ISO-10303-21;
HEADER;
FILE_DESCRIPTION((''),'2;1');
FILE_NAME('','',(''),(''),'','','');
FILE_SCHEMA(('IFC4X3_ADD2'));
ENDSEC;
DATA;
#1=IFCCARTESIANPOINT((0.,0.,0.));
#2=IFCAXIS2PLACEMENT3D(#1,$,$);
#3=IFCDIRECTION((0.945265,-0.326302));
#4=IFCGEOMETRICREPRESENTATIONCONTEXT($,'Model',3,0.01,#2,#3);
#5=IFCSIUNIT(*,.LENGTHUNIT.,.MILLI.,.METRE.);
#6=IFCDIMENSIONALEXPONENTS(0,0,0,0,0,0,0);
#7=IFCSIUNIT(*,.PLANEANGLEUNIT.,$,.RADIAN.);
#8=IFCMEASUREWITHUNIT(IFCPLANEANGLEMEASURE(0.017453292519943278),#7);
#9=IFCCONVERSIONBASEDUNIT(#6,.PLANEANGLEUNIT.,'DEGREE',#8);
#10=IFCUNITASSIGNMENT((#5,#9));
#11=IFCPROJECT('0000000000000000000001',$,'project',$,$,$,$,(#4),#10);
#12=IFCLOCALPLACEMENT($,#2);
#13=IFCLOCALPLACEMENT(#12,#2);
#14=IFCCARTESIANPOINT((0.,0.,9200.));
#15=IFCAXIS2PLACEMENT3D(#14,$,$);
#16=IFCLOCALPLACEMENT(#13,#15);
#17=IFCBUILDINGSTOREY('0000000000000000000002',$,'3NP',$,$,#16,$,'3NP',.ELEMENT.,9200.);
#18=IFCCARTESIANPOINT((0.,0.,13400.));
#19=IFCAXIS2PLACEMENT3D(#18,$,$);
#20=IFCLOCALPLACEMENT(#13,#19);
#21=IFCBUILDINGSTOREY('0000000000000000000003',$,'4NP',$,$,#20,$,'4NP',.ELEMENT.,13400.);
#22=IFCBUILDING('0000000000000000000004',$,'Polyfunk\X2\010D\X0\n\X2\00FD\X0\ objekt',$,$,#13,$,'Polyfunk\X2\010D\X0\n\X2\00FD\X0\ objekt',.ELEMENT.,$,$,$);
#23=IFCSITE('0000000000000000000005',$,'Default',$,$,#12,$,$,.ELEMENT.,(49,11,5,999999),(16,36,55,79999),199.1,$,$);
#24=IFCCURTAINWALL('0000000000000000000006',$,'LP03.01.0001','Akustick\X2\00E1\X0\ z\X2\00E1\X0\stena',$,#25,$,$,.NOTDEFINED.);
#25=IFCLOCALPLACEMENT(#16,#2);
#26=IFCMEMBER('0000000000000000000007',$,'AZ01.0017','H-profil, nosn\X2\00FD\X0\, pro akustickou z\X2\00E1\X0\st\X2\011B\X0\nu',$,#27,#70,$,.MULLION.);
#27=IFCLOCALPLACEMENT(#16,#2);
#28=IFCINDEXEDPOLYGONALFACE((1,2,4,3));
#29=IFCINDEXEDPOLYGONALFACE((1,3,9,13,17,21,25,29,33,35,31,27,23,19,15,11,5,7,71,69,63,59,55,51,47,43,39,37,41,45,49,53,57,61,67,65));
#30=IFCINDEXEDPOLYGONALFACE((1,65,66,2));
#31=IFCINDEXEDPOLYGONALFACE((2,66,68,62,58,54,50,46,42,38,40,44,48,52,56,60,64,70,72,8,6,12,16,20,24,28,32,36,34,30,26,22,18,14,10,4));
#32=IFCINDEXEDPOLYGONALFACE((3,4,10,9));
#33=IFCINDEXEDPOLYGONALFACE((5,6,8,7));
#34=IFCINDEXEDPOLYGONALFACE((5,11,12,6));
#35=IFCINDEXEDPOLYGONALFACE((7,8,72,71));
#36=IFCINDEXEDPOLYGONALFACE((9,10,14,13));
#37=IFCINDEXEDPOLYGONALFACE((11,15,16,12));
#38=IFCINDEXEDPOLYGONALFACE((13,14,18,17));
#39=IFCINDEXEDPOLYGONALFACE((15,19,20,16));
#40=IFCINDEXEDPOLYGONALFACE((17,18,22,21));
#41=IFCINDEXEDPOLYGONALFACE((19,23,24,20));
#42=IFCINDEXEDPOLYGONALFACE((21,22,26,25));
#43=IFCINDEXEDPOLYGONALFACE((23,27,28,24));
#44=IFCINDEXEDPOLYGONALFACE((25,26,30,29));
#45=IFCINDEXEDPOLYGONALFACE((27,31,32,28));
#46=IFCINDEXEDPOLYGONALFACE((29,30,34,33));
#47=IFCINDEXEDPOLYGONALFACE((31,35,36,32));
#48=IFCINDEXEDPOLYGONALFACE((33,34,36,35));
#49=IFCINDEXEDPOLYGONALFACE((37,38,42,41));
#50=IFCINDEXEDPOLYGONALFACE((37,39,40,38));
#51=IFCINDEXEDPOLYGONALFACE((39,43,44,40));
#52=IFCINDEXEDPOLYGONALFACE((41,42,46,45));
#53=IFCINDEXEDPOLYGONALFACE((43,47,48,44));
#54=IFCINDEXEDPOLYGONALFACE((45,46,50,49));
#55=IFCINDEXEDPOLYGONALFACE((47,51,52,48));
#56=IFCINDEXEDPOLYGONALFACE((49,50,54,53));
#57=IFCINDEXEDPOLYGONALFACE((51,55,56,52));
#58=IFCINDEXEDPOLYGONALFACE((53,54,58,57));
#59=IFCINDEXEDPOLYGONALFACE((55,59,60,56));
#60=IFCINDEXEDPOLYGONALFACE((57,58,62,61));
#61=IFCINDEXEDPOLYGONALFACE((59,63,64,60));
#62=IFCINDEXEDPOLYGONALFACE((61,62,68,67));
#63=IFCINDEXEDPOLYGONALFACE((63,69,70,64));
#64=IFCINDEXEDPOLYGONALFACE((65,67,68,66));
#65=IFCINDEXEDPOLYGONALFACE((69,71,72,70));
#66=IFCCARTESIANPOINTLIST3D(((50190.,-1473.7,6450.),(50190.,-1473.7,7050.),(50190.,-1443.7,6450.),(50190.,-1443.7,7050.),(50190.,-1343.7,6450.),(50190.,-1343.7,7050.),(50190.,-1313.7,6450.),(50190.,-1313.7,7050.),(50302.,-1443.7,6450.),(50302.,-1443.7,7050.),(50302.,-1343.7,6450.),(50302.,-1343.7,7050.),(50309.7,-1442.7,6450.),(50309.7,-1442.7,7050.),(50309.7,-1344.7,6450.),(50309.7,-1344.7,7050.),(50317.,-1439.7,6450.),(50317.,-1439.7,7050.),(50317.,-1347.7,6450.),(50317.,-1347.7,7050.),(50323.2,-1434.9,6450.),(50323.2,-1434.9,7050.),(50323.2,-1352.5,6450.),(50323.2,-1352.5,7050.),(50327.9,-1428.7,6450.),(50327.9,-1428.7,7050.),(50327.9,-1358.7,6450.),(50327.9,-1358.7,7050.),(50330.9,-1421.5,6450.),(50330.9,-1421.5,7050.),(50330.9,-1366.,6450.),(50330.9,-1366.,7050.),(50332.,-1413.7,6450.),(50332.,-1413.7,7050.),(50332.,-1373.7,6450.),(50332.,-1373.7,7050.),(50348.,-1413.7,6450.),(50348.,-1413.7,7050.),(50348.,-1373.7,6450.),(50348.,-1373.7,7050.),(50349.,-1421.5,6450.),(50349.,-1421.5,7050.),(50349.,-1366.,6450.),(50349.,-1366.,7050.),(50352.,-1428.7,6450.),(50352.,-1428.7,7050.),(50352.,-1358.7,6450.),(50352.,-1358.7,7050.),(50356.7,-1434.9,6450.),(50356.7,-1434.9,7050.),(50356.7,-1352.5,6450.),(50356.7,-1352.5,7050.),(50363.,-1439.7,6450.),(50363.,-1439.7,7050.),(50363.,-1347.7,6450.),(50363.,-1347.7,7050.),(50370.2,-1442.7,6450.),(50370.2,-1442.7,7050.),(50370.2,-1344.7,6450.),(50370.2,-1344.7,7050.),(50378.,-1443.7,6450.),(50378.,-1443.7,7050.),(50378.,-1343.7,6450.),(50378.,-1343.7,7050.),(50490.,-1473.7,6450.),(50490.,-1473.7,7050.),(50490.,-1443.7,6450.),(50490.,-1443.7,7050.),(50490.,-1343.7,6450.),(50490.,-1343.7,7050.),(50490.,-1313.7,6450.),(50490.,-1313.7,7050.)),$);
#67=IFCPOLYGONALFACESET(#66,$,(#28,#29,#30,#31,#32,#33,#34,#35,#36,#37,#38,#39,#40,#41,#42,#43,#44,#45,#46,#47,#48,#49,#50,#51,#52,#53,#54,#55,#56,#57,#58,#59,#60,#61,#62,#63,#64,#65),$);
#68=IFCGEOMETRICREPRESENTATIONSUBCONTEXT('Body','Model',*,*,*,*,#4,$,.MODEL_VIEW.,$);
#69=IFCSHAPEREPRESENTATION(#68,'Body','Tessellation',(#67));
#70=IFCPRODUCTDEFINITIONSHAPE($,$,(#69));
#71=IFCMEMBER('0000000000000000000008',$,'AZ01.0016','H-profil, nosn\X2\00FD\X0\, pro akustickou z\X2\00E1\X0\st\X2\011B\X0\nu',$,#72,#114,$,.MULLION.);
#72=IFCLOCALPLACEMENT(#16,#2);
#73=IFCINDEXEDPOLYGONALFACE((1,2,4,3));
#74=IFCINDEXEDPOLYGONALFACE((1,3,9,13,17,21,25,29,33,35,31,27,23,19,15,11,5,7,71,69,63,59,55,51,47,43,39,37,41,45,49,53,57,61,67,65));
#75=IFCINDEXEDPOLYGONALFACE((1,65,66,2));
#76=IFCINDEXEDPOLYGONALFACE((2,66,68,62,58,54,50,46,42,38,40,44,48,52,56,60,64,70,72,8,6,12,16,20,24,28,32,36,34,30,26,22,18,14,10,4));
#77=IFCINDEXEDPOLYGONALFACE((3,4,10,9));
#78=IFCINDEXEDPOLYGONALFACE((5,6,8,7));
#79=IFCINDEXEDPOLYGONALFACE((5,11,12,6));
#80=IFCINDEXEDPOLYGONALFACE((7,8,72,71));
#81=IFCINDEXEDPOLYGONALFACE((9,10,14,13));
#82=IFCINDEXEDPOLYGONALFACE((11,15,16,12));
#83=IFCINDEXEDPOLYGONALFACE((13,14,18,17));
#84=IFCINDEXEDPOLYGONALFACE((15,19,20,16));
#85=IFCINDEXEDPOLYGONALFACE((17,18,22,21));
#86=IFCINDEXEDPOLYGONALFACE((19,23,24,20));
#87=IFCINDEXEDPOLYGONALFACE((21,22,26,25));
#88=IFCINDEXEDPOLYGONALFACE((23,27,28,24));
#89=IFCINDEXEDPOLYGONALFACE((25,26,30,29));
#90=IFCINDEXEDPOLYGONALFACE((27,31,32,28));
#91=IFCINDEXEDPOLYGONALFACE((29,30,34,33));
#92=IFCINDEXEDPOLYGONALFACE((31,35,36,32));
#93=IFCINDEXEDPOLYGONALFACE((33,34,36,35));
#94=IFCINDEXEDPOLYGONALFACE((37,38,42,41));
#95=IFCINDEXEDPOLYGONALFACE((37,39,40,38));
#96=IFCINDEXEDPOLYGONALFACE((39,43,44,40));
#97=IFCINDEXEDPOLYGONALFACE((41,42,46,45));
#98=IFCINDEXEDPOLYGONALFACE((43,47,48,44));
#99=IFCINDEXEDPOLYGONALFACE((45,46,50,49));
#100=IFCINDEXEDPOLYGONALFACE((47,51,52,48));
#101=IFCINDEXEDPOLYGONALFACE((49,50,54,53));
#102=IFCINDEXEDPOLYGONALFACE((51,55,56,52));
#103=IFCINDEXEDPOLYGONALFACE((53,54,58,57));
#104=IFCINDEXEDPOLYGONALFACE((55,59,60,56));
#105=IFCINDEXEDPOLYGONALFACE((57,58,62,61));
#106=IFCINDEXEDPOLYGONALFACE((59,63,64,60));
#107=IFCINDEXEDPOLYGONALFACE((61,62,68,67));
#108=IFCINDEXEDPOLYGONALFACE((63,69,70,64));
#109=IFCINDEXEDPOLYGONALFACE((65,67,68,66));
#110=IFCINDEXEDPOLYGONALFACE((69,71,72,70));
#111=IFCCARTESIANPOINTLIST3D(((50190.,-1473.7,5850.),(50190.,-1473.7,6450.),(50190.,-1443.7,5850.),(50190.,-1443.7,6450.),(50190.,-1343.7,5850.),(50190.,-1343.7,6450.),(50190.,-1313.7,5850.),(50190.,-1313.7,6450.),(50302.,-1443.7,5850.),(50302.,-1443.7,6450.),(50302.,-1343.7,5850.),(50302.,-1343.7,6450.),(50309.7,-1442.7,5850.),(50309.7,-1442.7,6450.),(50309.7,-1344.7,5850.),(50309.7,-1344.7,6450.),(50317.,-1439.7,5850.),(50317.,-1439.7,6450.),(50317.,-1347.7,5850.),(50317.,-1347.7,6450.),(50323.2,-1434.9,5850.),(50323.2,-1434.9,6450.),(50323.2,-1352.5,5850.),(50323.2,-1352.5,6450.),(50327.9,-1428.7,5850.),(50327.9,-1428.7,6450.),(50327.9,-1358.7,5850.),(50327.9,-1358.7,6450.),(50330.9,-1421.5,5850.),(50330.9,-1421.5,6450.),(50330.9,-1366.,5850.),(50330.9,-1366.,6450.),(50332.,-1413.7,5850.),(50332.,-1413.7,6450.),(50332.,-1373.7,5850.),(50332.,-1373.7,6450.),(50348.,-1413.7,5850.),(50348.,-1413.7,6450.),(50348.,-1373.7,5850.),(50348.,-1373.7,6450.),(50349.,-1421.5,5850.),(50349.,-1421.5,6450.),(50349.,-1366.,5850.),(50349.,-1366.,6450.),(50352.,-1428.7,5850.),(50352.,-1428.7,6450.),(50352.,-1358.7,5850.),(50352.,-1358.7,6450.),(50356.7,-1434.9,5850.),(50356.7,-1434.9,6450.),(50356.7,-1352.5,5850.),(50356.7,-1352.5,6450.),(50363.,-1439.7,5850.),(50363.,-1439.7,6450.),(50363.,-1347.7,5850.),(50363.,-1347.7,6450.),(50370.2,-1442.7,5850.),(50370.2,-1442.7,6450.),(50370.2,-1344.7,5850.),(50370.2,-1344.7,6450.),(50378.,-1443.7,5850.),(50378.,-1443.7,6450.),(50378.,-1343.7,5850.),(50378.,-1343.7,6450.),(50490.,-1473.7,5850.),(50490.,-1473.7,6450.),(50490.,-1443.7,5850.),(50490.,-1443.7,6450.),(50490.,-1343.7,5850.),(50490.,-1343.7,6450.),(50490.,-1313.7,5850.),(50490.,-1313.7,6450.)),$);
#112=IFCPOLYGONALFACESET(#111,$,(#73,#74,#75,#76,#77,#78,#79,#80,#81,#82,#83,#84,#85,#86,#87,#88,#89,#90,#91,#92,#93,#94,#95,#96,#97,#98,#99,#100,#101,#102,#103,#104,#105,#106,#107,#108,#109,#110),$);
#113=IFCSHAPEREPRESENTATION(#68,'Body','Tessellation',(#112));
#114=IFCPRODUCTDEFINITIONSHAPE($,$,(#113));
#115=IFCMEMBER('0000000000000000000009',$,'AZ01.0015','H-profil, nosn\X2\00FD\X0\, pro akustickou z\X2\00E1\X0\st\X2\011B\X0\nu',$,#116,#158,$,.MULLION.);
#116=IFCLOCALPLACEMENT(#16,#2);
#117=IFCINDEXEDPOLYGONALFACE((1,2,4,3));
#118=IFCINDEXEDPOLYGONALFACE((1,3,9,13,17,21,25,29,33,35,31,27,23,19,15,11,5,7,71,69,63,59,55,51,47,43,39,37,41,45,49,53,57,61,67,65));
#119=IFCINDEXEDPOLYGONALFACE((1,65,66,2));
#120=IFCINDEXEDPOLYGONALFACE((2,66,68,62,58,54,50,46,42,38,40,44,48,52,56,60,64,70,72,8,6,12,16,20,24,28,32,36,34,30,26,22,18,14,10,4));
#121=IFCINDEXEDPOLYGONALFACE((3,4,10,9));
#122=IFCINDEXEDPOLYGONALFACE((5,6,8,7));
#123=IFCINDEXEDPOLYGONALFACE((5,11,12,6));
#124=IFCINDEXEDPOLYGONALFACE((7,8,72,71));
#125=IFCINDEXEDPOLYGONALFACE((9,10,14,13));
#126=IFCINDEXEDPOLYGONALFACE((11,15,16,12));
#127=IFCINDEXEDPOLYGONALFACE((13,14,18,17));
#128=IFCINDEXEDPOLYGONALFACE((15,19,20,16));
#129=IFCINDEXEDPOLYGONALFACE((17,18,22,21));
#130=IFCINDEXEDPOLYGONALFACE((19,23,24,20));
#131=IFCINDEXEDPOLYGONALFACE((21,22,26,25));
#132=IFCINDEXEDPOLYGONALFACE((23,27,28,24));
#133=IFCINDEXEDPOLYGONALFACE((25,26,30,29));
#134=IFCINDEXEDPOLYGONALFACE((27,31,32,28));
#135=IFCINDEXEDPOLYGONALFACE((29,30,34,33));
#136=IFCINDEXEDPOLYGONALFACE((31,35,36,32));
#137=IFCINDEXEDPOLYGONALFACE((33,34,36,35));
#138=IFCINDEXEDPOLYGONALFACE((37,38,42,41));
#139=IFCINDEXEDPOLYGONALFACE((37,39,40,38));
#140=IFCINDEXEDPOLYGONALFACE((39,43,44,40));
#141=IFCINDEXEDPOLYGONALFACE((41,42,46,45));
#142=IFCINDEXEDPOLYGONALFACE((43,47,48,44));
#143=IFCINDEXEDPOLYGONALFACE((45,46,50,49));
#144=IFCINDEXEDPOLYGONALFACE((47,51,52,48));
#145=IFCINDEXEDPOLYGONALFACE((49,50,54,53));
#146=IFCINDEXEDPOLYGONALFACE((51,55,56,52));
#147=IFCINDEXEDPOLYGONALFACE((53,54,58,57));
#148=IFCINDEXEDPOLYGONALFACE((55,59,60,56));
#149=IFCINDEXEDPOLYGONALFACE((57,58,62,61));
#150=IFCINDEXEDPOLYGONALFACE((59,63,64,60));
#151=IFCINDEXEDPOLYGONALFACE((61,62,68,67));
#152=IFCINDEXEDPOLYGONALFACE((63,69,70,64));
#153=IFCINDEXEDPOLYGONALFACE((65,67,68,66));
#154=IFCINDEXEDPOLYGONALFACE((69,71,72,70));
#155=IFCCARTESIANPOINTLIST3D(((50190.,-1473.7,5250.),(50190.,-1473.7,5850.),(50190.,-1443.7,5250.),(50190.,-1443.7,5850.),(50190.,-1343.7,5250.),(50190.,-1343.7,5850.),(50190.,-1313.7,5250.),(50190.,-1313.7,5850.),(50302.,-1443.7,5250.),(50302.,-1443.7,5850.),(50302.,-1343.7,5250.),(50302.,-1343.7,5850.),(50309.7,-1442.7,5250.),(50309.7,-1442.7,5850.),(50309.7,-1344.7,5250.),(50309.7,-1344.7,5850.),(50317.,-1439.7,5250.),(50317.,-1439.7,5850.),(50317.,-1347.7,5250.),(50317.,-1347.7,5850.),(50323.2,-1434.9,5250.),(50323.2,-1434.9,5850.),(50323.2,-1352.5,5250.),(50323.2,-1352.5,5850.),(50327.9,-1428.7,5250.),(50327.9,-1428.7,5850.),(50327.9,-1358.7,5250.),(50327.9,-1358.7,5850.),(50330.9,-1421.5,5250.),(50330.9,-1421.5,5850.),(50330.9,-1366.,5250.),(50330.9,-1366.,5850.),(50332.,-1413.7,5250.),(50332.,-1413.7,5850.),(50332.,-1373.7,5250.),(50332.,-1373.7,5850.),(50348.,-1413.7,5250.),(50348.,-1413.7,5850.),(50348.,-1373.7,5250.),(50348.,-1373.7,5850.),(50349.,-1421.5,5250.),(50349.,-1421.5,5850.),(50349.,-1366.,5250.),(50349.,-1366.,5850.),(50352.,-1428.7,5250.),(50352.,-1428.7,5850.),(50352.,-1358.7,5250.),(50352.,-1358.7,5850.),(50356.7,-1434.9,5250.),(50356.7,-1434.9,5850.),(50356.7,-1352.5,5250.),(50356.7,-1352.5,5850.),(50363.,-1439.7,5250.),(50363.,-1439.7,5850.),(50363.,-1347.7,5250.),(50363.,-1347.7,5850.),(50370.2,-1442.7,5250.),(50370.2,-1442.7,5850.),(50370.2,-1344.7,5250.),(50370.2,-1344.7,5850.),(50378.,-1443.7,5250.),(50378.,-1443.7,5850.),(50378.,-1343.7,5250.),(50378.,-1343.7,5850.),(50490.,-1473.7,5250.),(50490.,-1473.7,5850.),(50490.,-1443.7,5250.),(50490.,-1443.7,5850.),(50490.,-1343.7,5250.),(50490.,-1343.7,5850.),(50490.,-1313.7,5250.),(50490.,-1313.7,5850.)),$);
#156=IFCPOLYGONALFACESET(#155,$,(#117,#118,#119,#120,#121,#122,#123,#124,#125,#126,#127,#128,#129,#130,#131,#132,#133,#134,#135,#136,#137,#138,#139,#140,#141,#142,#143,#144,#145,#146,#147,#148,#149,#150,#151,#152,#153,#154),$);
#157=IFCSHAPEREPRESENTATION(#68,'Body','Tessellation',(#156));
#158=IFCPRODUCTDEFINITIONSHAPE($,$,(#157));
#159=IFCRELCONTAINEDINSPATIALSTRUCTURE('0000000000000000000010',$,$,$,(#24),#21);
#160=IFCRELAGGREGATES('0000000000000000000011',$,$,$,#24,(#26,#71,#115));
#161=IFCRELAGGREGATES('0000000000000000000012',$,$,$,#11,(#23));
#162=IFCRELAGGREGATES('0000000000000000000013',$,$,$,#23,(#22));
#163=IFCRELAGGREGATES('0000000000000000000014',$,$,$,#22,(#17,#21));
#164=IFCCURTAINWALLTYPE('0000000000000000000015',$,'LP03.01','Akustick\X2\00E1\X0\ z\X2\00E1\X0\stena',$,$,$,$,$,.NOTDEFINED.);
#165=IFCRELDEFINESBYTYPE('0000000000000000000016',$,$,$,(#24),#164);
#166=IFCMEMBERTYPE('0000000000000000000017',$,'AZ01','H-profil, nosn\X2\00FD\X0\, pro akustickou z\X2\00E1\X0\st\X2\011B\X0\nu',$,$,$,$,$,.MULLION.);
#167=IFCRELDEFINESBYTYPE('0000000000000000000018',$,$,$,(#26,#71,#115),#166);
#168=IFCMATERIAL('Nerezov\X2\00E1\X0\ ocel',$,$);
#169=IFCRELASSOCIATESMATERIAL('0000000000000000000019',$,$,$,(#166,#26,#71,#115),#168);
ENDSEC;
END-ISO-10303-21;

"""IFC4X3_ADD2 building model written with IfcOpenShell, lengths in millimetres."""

from ifc_helpers import new_model, entity, si_unit, converted_unit, direction, frame, frame_2d, origin, place, context, subcontext, project, spatial, polyline, circle_curve, parameter, trimmed, segment, composite_curve, outline, extrude, source, transform, mapped, material, material_profile, profile_set, profile_usage, type_object, element, aggregate, save


model = new_model("IFC4X3_ADD2")

# Units and contexts
model_context = context("Model", 3, precision=0.01, world=origin(), true_north=direction((0.945265, -0.326302)))
body_context = subcontext(model_context, "Body", "Model", "MODEL_VIEW")
ifc_project = project(units=[si_unit("LENGTHUNIT", "METRE", prefix="MILLI"), converted_unit("PLANEANGLEUNIT", "DEGREE", entity("IfcPlaneAngleMeasure", 0.017453292519943278), si_unit("PLANEANGLEUNIT", "RADIAN"), dimensions=[0, 0, 0, 0, 0, 0, 0])], contexts=[model_context])

# Site, building, storey
site_placement = place(None, origin())
site = spatial("IfcSite", under=ifc_project, at=site_placement, Name="Default", CompositionType="ELEMENT", RefLatitude=(49, 11, 5, 999999), RefLongitude=(16, 36, 55, 79999), RefElevation=199.1)
building_placement = place(site_placement, origin())
building = spatial("IfcBuilding", under=site, at=building_placement, Name="Polyfunkčný objekt", LongName="Polyfunkčný objekt", CompositionType="ELEMENT")
storey_1_placement = place(building_placement, frame((0.0, 0.0, 9200.0)))
storey_1 = spatial("IfcBuildingStorey", under=building, at=storey_1_placement, Name="3NP", LongName="3NP", CompositionType="ELEMENT", Elevation=9200.0)

# Shared definitions
storey_2_placement = place(building_placement, frame((0.0, 0.0, 13400.0)))
storey_2 = spatial("IfcBuildingStorey", under=building, at=storey_2_placement, Name="4NP", LongName="4NP", CompositionType="ELEMENT", Elevation=13400.0)

# Curtain wall, members
curtain_wall_type_1 = type_object("IfcCurtainWallType", Name="LP03.01", Description="Akustická zástena", PredefinedType="NOTDEFINED")
ifc_material_1 = material(Name="Nerezová ocel")
ifc_material_profile_1 = material_profile(ifc_material_1, outline(composite_curve([segment(polyline([(50.0, -150.0), (80.0, -150.0)]), True, "CONTINUOUS"), segment(polyline([(80.0, -150.0), (80.0, 150.0)]), True, "CONTINUOUS"), segment(polyline([(80.0, 150.0), (50.0, 150.0)]), True, "CONTINUOUS"), segment(polyline([(50.0, 150.0), (50.0, 38.0)]), True, "CONTINUOUS"), segment(trimmed(circle_curve(frame_2d((20.0, 38.0), x_axis=(0.0, 1.0)), 30.0), [parameter(180.0)], [parameter(270.0)], True, "PARAMETER"), False, "CONTINUOUS"), segment(polyline([(20.0, 8.0), (-20.0, 8.0)]), True, "CONTINUOUS"), segment(trimmed(circle_curve(frame_2d((-20.0, 38.0), x_axis=(0.0, 1.0)), 30.0), [parameter(90.0)], [parameter(180.0)], True, "PARAMETER"), False, "CONTINUOUS"), segment(polyline([(-50.0, 38.0), (-50.0, 150.0)]), True, "CONTINUOUS"), segment(polyline([(-50.0, 150.0), (-80.0, 150.0)]), True, "CONTINUOUS"), segment(polyline([(-80.0, 150.0), (-80.0, -150.0)]), True, "CONTINUOUS"), segment(polyline([(-80.0, -150.0), (-50.0, -150.0)]), True, "CONTINUOUS"), segment(polyline([(-50.0, -150.0), (-50.0, -38.0)]), True, "CONTINUOUS"), segment(trimmed(circle_curve(frame_2d((-20.0, -38.0), x_axis=(0.0, 1.0)), 30.0), [parameter(0.0)], [parameter(90.0)], True, "PARAMETER"), False, "CONTINUOUS"), segment(polyline([(-20.0, -8.0), (20.0, -8.0)]), True, "CONTINUOUS"), segment(trimmed(circle_curve(frame_2d((20.0, -38.0), x_axis=(0.0, 1.0)), 30.0), [parameter(270.0)], [parameter(0.0)], True, "PARAMETER"), False, "CONTINUOUS"), segment(polyline([(50.0, -38.0), (50.0, -150.0)]), True, "CONTINUOUS")], self_intersect=False)), Name="Profil zástena")
ifc_profile_set_1 = profile_set([ifc_material_profile_1], Name="Profil zástena")
ifc_profile_usage_1 = profile_usage(ifc_profile_set_1)
member_type_1 = type_object("IfcMemberType", Name="AZ01", Description="H-profil, nosný, pro akustickou zástěnu", PredefinedType="MULLION", material=ifc_profile_set_1)
shared_shape_1 = source(origin(), body_context, "Body", "SweptSolid", [
    extrude(outline(composite_curve([segment(polyline([(-150.0, -50.0), (-150.0, -80.0)]), True, "CONTINUOUS"), segment(polyline([(-150.0, -80.0), (150.0, -80.0)]), True, "CONTINUOUS"), segment(polyline([(150.0, -80.0), (150.0, -50.0)]), True, "CONTINUOUS"), segment(polyline([(150.0, -50.0), (38.0, -50.0)]), True, "CONTINUOUS"), segment(trimmed(circle_curve(frame_2d((38.0, -20.0), x_axis=(1.0, 0.0)), 30.0), [parameter(180.0)], [parameter(270.0)], True, "PARAMETER"), False, "CONTINUOUS"), segment(polyline([(8.0, -20.0), (8.0, 20.0)]), True, "CONTINUOUS"), segment(trimmed(circle_curve(frame_2d((38.0, 20.0), x_axis=(1.0, 0.0)), 30.0), [parameter(90.0)], [parameter(180.0)], True, "PARAMETER"), False, "CONTINUOUS"), segment(polyline([(38.0, 50.0), (150.0, 50.0)]), True, "CONTINUOUS"), segment(polyline([(150.0, 50.0), (150.0, 80.0)]), True, "CONTINUOUS"), segment(polyline([(150.0, 80.0), (-150.0, 80.0)]), True, "CONTINUOUS"), segment(polyline([(-150.0, 80.0), (-150.0, 50.0)]), True, "CONTINUOUS"), segment(polyline([(-150.0, 50.0), (-38.0, 50.0)]), True, "CONTINUOUS"), segment(trimmed(circle_curve(frame_2d((-38.0, 20.0), x_axis=(1.0, 0.0)), 30.0), [parameter(0.0)], [parameter(90.0)], True, "PARAMETER"), False, "CONTINUOUS"), segment(polyline([(-8.0, 20.0), (-8.0, -20.0)]), True, "CONTINUOUS"), segment(trimmed(circle_curve(frame_2d((-38.0, -20.0), x_axis=(1.0, 0.0)), 30.0), [parameter(270.0)], [parameter(0.0)], True, "PARAMETER"), False, "CONTINUOUS"), segment(polyline([(-38.0, -50.0), (-150.0, -50.0)]), True, "CONTINUOUS")], self_intersect=False)), frame((-150.0, 0.0, -600.0), z_axis=(0.0, 0.0, -1.0), x_axis=(-1.0, 0.0, 0.0)), (0.0, 0.0, -1.0), 600.0),
])
curtain_wall_1_placement = place(storey_2_placement, frame((0.0, 0.0, -13400.0)))
curtain_wall_1 = element("IfcCurtainWall", 1, at=curtain_wall_1_placement, inside=storey_2, type_object=curtain_wall_type_1, Name="LP03.01.0001", Description="Akustická zástena", PredefinedType="NOTDEFINED")
member_1_placement = place(curtain_wall_1_placement, frame((50190.0, -1393.7, 16250.0), z_axis=(0.0, 0.0, 1.0), x_axis=(-1.0, 0.0, 0.0)))
member_1 = element("IfcMember", 2, at=member_1_placement, type_object=member_type_1, material=ifc_profile_usage_1, Name="AZ01.0017", Description="H-profil, nosný, pro akustickou zástěnu", PredefinedType="MULLION", context=body_context, shape_type="MappedRepresentation", body=[
    mapped(shared_shape_1, transform((0.0, 0.0, 0.0), scale=1.0)),
])
member_2_placement = place(curtain_wall_1_placement, frame((50190.0, -1393.7, 15650.0), z_axis=(0.0, 0.0, 1.0), x_axis=(-1.0, 0.0, 0.0)))
member_2 = element("IfcMember", 3, at=member_2_placement, type_object=member_type_1, material=ifc_profile_usage_1, Name="AZ01.0016", Description="H-profil, nosný, pro akustickou zástěnu", PredefinedType="MULLION", context=body_context, shape_type="MappedRepresentation", body=[
    mapped(shared_shape_1, transform((0.0, 0.0, 0.0), scale=1.0)),
])
member_3_placement = place(curtain_wall_1_placement, frame((50190.0, -1393.7, 15050.0), z_axis=(0.0, 0.0, 1.0), x_axis=(-1.0, 0.0, 0.0)))
member_3 = element("IfcMember", 4, at=member_3_placement, type_object=member_type_1, material=ifc_profile_usage_1, Name="AZ01.0015", Description="H-profil, nosný, pro akustickou zástěnu", PredefinedType="MULLION", context=body_context, shape_type="MappedRepresentation", body=[
    mapped(shared_shape_1, transform((0.0, 0.0, 0.0), scale=1.0)),
])

aggregate(curtain_wall_1, [member_1, member_2, member_3])

save(model, "model.ifc")
